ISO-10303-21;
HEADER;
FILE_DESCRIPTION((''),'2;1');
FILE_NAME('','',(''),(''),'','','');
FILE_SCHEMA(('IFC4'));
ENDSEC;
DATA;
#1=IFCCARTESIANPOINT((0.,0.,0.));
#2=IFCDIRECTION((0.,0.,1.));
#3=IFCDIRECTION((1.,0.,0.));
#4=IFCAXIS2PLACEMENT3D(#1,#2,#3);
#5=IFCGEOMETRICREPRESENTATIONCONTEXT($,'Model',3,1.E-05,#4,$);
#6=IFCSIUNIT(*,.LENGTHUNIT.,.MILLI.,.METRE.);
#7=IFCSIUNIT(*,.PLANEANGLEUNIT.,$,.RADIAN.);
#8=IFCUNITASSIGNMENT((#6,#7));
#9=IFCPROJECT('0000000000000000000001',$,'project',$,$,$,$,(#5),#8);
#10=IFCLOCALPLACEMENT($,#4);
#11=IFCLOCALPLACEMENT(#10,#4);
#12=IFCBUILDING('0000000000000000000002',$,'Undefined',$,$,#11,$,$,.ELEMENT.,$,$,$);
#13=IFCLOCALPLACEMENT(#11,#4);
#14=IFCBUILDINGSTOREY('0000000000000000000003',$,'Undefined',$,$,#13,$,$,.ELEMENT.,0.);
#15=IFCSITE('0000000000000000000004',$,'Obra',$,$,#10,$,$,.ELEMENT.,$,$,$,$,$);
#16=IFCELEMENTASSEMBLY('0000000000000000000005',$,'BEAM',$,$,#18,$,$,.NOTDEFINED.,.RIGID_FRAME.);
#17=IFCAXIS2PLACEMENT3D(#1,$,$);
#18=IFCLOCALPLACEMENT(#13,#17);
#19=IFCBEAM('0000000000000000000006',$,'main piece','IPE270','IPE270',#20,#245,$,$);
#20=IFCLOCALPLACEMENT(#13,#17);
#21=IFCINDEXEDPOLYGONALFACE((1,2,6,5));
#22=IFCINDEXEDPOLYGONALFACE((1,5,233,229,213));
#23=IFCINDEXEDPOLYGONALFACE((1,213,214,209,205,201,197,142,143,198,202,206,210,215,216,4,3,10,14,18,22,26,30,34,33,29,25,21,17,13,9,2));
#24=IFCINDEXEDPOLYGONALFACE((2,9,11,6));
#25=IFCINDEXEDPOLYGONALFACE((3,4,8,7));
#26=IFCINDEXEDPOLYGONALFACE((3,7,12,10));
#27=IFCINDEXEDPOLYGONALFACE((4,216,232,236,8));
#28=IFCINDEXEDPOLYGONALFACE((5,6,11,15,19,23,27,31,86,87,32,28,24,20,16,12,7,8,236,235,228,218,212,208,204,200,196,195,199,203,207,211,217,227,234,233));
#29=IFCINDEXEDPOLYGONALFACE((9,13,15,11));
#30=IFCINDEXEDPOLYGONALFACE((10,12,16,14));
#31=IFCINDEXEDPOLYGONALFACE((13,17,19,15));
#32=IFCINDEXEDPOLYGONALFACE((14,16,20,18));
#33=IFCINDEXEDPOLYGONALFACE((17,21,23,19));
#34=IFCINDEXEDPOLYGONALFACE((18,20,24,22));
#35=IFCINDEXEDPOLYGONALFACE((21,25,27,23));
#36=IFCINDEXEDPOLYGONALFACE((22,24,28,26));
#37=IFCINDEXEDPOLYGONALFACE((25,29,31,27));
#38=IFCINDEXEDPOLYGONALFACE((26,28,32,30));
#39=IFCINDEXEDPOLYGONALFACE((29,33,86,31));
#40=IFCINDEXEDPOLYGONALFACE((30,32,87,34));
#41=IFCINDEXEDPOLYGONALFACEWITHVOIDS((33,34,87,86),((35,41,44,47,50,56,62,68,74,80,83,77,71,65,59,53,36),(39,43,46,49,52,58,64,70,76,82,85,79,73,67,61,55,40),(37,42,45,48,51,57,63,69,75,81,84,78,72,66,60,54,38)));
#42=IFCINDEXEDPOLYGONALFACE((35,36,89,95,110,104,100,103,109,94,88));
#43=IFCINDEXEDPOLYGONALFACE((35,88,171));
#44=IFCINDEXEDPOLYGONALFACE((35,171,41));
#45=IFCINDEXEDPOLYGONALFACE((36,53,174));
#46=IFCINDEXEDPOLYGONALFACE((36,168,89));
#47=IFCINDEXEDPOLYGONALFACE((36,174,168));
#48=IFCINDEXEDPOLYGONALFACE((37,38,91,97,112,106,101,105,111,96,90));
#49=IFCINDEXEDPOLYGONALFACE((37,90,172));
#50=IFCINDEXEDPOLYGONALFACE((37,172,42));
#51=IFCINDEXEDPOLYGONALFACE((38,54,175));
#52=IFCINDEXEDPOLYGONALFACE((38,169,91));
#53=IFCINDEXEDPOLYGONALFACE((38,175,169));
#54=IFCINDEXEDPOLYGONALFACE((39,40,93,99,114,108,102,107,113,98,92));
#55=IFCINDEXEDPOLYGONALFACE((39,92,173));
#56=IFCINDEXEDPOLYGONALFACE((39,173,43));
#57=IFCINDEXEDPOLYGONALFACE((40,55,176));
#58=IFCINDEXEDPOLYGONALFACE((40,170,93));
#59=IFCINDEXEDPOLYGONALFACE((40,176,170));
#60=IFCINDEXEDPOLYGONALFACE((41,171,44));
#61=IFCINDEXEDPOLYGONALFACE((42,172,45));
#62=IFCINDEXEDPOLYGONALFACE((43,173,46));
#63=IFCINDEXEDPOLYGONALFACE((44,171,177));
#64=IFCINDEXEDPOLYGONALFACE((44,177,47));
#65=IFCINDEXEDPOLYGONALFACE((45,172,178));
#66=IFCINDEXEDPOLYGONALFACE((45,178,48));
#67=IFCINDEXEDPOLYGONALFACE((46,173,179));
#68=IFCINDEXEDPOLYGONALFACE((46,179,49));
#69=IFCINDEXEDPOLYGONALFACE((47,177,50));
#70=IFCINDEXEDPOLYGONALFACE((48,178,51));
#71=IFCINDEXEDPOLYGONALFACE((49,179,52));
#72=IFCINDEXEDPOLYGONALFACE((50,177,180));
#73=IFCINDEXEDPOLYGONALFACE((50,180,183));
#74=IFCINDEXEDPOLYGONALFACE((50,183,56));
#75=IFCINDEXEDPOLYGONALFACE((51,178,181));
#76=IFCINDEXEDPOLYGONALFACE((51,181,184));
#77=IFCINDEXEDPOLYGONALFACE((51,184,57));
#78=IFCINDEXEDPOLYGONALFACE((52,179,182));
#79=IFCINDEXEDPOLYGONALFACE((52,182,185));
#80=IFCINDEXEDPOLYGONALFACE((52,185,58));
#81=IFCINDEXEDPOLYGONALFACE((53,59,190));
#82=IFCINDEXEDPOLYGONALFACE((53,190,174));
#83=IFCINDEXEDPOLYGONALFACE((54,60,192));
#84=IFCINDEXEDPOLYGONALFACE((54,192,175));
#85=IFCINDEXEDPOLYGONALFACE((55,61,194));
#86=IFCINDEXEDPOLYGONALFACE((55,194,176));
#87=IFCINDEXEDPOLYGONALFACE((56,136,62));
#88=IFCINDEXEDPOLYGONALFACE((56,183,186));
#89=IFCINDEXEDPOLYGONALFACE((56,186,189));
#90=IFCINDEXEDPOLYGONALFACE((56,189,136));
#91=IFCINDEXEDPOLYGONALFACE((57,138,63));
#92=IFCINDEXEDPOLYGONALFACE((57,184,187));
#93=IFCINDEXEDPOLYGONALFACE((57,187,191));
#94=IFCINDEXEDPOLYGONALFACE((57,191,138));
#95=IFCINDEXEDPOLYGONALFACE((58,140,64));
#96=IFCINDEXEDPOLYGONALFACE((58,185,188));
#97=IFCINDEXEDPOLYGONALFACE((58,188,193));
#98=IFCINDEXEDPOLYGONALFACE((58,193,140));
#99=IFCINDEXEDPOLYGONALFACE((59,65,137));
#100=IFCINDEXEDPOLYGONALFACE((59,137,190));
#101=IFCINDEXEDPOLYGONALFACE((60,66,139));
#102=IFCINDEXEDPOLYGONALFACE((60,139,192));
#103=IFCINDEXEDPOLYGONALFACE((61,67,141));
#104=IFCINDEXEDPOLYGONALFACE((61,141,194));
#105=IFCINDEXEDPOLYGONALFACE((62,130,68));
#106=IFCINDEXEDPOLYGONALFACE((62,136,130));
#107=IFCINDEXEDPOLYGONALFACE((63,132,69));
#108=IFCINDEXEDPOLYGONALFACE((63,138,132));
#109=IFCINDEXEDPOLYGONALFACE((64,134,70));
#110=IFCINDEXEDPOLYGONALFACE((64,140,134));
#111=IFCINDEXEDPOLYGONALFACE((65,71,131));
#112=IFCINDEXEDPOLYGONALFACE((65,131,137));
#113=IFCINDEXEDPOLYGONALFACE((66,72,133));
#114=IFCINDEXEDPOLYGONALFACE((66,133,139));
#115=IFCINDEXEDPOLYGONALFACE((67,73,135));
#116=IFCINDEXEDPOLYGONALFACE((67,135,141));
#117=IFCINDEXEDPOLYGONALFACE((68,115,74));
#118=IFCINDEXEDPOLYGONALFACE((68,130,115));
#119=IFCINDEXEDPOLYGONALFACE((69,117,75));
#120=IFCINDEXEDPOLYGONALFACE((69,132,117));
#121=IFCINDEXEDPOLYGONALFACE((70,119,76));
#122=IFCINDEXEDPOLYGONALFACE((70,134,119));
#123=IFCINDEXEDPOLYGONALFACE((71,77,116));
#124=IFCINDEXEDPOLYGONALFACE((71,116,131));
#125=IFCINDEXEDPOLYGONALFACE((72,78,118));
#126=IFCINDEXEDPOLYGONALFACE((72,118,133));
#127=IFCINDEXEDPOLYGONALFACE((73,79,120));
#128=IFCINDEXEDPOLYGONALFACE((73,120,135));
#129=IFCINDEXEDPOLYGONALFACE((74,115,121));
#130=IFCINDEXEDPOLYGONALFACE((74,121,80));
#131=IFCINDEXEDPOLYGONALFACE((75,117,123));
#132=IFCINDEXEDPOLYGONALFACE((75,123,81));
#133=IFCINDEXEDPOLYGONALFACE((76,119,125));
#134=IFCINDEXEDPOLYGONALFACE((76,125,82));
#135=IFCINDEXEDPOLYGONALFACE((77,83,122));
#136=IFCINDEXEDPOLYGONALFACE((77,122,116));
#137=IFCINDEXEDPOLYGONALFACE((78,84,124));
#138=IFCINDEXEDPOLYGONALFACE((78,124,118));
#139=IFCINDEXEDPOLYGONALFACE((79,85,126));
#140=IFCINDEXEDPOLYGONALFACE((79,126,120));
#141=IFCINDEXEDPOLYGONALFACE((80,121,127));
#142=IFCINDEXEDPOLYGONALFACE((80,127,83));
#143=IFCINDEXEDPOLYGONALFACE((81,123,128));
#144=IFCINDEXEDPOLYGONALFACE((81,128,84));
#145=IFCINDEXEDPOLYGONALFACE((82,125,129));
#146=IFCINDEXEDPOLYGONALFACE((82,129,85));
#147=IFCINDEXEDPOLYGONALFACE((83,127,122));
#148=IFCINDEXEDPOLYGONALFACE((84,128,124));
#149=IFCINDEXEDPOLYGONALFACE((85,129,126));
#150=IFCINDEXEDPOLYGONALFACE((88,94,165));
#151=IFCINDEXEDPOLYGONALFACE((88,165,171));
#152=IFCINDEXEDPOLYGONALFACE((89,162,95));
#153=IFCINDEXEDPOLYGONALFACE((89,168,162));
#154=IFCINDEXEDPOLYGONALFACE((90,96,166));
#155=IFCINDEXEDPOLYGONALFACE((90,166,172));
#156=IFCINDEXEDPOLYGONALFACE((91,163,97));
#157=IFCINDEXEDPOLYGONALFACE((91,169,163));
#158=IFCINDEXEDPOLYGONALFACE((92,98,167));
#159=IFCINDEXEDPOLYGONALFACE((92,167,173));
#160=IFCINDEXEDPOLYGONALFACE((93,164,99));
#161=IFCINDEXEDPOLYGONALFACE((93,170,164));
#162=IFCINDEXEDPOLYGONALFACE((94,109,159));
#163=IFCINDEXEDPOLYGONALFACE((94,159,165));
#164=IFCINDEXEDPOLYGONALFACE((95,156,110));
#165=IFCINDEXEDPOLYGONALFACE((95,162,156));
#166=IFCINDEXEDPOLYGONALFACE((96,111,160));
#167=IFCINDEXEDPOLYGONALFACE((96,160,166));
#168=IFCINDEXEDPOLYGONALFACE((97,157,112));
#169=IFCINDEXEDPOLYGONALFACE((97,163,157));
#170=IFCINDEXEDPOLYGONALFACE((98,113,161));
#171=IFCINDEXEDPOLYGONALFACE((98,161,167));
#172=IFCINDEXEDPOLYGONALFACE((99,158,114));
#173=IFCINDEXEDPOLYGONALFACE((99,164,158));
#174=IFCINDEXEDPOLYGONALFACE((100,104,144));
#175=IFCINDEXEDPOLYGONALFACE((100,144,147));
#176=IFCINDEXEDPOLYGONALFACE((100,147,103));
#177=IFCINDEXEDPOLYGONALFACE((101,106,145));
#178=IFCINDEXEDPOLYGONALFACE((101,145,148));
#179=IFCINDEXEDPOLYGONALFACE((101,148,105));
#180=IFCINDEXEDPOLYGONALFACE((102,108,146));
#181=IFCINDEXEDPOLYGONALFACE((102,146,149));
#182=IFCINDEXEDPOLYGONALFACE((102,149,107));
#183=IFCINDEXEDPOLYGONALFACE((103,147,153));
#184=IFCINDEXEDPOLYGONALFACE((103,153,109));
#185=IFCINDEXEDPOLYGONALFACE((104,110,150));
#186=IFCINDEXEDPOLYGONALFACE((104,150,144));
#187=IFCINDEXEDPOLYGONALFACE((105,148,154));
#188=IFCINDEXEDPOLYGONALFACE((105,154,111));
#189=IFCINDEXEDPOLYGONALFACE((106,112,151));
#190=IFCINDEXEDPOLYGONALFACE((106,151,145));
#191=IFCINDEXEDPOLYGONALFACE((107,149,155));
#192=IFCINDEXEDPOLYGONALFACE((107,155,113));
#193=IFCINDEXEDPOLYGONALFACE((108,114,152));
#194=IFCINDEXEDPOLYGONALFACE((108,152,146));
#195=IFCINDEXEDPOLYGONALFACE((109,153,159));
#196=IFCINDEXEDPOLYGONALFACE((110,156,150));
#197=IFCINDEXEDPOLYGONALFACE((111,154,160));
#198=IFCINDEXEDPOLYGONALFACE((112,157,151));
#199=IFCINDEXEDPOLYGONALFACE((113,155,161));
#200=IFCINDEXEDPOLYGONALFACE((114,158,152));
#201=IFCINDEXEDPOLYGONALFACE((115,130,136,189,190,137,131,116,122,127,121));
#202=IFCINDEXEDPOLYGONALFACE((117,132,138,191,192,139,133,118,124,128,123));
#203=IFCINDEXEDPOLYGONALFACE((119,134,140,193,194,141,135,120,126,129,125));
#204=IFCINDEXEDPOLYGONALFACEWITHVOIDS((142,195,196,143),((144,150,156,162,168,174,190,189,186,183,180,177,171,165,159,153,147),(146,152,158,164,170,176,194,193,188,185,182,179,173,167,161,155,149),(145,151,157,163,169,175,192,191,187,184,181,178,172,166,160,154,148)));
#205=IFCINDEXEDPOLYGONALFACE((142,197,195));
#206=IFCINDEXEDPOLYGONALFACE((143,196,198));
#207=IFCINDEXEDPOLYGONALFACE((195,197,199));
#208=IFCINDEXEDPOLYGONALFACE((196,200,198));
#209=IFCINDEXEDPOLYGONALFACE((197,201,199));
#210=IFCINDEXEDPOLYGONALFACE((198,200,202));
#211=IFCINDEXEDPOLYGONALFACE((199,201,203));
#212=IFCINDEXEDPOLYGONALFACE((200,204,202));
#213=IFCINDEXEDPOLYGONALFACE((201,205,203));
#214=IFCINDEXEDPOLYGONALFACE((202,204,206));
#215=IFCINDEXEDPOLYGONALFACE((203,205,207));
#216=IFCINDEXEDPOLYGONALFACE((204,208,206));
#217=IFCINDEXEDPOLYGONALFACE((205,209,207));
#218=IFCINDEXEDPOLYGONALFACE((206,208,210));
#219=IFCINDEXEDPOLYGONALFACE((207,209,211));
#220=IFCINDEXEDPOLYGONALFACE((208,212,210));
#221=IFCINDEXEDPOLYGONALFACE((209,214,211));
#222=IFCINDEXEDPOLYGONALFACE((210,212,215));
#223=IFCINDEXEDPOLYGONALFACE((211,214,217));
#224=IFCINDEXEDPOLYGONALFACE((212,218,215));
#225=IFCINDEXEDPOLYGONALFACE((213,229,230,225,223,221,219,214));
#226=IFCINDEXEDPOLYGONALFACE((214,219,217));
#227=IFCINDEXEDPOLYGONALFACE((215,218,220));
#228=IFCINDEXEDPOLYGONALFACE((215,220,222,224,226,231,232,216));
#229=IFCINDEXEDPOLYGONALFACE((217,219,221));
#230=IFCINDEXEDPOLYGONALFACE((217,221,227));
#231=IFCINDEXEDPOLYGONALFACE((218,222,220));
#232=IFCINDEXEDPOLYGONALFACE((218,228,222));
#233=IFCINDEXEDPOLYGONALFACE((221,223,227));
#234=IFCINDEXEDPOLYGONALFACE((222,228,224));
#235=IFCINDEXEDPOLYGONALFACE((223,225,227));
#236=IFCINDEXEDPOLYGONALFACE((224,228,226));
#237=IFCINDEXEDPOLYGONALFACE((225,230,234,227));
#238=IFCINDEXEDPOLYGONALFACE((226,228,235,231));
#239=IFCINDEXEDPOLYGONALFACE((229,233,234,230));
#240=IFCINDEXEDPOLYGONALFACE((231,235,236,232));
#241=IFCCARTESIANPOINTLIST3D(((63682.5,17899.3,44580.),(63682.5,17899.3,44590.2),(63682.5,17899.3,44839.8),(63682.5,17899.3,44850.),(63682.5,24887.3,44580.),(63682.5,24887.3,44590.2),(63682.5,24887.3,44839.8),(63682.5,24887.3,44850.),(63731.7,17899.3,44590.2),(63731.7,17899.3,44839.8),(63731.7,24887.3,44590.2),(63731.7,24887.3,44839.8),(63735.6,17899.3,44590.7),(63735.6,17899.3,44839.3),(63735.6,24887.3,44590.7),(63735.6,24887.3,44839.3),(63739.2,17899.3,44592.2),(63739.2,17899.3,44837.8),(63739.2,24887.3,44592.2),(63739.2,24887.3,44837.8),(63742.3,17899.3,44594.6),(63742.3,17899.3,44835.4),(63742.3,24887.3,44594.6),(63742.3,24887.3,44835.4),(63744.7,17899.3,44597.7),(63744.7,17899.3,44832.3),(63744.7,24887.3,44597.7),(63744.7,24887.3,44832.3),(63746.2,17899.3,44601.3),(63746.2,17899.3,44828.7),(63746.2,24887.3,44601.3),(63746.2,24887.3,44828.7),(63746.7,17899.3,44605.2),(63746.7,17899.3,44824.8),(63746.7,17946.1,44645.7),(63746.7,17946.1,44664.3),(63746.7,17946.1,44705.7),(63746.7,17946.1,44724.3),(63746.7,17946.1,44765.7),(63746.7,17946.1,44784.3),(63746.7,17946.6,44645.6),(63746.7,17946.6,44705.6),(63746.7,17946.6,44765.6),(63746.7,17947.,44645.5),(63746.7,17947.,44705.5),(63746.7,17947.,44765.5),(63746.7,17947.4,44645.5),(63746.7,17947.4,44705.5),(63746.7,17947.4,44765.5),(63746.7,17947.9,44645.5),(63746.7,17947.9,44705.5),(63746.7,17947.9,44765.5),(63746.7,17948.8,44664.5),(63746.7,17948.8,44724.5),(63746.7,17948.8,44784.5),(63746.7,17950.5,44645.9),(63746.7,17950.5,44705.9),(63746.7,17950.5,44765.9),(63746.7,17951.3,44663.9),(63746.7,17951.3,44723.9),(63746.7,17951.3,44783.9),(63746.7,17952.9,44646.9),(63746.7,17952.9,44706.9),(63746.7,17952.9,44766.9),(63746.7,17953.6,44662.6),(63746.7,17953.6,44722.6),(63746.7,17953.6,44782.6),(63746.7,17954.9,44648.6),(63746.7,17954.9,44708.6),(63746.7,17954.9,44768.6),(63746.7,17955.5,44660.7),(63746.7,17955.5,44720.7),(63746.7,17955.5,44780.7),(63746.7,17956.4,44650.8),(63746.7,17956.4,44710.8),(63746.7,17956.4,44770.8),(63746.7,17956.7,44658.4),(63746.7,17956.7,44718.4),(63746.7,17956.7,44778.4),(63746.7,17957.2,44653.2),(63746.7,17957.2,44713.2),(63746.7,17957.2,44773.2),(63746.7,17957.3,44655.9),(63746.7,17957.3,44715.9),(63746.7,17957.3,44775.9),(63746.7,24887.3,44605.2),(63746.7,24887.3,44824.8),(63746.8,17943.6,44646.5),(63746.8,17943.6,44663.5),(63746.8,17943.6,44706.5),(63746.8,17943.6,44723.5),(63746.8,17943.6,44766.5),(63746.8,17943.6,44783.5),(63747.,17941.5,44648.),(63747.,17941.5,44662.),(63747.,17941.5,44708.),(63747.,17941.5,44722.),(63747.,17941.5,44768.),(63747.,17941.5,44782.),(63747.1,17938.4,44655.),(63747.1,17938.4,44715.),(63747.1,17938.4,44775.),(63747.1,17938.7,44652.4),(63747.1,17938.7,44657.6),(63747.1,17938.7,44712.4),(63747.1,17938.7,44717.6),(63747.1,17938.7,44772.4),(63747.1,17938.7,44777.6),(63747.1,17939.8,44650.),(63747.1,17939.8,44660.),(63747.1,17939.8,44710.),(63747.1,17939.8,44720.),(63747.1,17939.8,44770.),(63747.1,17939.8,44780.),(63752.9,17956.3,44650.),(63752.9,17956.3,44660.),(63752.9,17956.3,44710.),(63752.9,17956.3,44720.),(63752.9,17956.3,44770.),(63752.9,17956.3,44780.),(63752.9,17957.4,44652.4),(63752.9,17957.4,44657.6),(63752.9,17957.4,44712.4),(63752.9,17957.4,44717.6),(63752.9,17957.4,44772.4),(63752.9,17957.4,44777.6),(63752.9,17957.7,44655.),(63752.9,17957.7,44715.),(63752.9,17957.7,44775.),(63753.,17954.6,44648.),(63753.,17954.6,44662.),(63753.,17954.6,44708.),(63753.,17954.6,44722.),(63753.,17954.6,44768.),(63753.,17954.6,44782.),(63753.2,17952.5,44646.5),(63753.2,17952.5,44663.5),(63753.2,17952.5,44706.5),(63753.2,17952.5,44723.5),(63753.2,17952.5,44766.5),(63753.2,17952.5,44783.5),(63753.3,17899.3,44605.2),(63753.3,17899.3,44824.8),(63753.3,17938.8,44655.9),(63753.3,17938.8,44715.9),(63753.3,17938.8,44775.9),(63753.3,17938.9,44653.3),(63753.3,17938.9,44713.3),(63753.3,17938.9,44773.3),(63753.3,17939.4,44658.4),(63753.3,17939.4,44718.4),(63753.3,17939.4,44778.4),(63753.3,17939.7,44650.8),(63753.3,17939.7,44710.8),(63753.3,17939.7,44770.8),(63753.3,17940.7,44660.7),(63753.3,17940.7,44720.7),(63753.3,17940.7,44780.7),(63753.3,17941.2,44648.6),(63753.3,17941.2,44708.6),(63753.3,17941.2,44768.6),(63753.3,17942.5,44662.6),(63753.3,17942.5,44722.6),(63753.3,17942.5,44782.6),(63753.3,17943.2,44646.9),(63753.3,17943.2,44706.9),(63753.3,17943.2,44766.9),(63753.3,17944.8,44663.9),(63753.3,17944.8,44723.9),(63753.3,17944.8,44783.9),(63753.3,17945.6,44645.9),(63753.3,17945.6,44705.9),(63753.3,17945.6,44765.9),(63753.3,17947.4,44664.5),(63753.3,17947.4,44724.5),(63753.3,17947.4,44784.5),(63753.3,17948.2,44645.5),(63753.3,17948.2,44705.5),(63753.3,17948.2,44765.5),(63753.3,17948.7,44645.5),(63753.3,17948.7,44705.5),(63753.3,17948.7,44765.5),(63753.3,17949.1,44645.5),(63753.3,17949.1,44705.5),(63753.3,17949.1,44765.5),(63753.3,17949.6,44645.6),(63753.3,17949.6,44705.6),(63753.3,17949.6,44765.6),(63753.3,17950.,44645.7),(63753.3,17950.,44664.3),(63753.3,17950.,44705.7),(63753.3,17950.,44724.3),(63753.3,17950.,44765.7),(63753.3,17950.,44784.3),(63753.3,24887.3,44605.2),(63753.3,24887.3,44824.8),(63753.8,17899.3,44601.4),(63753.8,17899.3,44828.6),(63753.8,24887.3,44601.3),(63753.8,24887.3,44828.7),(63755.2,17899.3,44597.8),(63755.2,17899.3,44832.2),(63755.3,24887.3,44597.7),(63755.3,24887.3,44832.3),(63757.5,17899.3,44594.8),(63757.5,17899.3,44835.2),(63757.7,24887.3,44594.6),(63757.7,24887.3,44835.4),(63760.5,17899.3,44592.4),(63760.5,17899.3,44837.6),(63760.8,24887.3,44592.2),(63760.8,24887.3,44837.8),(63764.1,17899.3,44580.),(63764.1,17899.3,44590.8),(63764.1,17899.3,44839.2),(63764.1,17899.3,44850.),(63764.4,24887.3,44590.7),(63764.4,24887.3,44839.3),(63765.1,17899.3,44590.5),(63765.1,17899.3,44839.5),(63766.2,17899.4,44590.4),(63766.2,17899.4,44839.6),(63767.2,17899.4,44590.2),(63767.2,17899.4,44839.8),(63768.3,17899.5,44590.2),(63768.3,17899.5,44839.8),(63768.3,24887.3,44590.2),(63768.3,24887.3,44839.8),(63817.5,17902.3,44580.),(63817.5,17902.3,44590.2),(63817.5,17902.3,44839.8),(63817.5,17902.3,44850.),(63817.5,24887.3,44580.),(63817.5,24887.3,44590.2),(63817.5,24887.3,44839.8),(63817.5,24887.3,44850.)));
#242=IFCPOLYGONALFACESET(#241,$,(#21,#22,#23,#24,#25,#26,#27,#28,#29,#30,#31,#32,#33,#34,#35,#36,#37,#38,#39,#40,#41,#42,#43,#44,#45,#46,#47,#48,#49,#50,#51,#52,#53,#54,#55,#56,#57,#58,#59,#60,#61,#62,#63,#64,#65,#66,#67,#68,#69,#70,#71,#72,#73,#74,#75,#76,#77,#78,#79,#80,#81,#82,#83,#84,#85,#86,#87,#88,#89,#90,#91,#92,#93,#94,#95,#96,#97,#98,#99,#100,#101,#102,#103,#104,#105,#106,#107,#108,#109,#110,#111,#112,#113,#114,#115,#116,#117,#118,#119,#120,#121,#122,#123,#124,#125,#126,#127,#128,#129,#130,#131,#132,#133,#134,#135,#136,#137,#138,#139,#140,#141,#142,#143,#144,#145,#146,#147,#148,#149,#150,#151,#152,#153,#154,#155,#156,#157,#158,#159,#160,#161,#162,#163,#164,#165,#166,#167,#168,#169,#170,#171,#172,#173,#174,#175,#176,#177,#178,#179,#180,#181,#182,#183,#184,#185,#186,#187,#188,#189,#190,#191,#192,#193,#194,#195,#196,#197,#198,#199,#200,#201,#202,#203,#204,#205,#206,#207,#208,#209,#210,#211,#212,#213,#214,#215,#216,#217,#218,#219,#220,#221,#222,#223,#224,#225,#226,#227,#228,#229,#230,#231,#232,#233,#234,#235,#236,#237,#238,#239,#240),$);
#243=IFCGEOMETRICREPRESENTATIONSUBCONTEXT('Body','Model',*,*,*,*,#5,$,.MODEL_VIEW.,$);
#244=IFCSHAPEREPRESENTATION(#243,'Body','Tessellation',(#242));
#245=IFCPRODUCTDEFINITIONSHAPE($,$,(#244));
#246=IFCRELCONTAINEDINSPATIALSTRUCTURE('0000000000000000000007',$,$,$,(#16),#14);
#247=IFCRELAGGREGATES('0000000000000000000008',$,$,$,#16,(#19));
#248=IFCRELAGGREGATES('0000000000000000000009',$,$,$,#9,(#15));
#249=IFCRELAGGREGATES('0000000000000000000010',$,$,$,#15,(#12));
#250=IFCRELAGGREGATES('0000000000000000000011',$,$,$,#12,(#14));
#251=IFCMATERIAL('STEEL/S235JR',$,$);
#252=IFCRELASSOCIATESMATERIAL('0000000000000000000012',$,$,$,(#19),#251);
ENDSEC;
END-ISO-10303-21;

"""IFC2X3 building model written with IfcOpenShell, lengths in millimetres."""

from ifc_helpers import new_model, si_unit, frame, origin_with_axes, origin_2d_with_axis, place, context, subcontext, project, spatial, circle, i_section, extrude, clip, halfspace, source, transform, mapped, material, element, aggregate, save


model = new_model("IFC2X3")

# Units and contexts
model_context = context("Model", 3, precision=1e-05, world=origin_with_axes())
body_context = subcontext(model_context, "Body", "Model", "MODEL_VIEW")
ifc_project = project(units=[si_unit("LENGTHUNIT", "METRE", prefix="MILLI"), si_unit("PLANEANGLEUNIT", "RADIAN")], contexts=[model_context])

# Site, building, storey
site_placement = place(None, origin_with_axes())
site = spatial("IfcSite", under=ifc_project, at=site_placement, Name="Obra", CompositionType="ELEMENT")
building_placement = place(site_placement, origin_with_axes())
building = spatial("IfcBuilding", under=site, at=building_placement, Name="Undefined", CompositionType="ELEMENT")
storey_placement = place(building_placement, origin_with_axes())
storey = spatial("IfcBuildingStorey", under=building, at=storey_placement, Name="Undefined", CompositionType="ELEMENT", Elevation=0.0)

# Shared definitions
ifc_material_1 = material(Name="STEEL/S235JR")

# Element assembly, beam, opening
assembly_1_placement = place(storey_placement, origin_with_axes())
assembly_1 = element("IfcElementAssembly", 1, at=assembly_1_placement, inside=storey, Name="BEAM", AssemblyPlace="NOTDEFINED", PredefinedType="RIGID_FRAME")
beam_1_placement = place(assembly_1_placement, frame((63750.0, 17899.3, 44715.0), z_axis=(0.0, 0.0, 1.0), x_axis=(0.0, 1.0, 0.0)))
beam_1 = element("IfcBeam", 2, at=beam_1_placement, material=ifc_material_1, Name="main piece", Description="IPE270", ObjectType="IPE270", context=body_context, shape_type="Clipping", body=[
    clip(extrude(i_section(OverallWidth=135.0, OverallDepth=270.0, WebThickness=6.6, FlangeThickness=10.2, FilletRadius=15.0, at=origin_2d_with_axis()), frame((6988.1, 0.0, 0.0), z_axis=(-1.0, 0.0, 0.0), x_axis=(0.0, -1.0, 0.0)), (0.0, 0.0, 1.0), 6988.1), halfspace(frame((-5.9, 89.1, -120.0), z_axis=(-0.998367, -0.057126, 0.0), x_axis=(0.0, 0.0, 1.0)), False)),
])
shared_shape_1 = source(origin_with_axes(), body_context, "Body", "SweptSolid", [
    extrude(circle(Radius=9.5, at=origin_2d_with_axis()), frame((0.0, -35.4, 0.0), z_axis=(0.0, 1.0, 0.0), x_axis=(1.0, 0.0, 0.0)), (0.0, 0.0, 1.0), 6.8),
])
opening_1_placement = place(assembly_1_placement, frame((63720.9, 17896.3, 44835.0), z_axis=(-0.057107, 0.998368, 0.0), x_axis=(0.0, 0.0, -1.0)))
element("IfcOpeningElement", 3, at=opening_1_placement, cuts=beam_1, ObjectType="Opening", context=body_context, shape_type="MappedRepresentation", body=[
    mapped(shared_shape_1, transform((60.0, 0.0, 50.0))),
    mapped(shared_shape_1, transform((120.0, 0.0, 50.0))),
    mapped(shared_shape_1, transform((180.0, 0.0, 50.0))),
])

aggregate(assembly_1, [beam_1])

save(model, "model.ifc")
